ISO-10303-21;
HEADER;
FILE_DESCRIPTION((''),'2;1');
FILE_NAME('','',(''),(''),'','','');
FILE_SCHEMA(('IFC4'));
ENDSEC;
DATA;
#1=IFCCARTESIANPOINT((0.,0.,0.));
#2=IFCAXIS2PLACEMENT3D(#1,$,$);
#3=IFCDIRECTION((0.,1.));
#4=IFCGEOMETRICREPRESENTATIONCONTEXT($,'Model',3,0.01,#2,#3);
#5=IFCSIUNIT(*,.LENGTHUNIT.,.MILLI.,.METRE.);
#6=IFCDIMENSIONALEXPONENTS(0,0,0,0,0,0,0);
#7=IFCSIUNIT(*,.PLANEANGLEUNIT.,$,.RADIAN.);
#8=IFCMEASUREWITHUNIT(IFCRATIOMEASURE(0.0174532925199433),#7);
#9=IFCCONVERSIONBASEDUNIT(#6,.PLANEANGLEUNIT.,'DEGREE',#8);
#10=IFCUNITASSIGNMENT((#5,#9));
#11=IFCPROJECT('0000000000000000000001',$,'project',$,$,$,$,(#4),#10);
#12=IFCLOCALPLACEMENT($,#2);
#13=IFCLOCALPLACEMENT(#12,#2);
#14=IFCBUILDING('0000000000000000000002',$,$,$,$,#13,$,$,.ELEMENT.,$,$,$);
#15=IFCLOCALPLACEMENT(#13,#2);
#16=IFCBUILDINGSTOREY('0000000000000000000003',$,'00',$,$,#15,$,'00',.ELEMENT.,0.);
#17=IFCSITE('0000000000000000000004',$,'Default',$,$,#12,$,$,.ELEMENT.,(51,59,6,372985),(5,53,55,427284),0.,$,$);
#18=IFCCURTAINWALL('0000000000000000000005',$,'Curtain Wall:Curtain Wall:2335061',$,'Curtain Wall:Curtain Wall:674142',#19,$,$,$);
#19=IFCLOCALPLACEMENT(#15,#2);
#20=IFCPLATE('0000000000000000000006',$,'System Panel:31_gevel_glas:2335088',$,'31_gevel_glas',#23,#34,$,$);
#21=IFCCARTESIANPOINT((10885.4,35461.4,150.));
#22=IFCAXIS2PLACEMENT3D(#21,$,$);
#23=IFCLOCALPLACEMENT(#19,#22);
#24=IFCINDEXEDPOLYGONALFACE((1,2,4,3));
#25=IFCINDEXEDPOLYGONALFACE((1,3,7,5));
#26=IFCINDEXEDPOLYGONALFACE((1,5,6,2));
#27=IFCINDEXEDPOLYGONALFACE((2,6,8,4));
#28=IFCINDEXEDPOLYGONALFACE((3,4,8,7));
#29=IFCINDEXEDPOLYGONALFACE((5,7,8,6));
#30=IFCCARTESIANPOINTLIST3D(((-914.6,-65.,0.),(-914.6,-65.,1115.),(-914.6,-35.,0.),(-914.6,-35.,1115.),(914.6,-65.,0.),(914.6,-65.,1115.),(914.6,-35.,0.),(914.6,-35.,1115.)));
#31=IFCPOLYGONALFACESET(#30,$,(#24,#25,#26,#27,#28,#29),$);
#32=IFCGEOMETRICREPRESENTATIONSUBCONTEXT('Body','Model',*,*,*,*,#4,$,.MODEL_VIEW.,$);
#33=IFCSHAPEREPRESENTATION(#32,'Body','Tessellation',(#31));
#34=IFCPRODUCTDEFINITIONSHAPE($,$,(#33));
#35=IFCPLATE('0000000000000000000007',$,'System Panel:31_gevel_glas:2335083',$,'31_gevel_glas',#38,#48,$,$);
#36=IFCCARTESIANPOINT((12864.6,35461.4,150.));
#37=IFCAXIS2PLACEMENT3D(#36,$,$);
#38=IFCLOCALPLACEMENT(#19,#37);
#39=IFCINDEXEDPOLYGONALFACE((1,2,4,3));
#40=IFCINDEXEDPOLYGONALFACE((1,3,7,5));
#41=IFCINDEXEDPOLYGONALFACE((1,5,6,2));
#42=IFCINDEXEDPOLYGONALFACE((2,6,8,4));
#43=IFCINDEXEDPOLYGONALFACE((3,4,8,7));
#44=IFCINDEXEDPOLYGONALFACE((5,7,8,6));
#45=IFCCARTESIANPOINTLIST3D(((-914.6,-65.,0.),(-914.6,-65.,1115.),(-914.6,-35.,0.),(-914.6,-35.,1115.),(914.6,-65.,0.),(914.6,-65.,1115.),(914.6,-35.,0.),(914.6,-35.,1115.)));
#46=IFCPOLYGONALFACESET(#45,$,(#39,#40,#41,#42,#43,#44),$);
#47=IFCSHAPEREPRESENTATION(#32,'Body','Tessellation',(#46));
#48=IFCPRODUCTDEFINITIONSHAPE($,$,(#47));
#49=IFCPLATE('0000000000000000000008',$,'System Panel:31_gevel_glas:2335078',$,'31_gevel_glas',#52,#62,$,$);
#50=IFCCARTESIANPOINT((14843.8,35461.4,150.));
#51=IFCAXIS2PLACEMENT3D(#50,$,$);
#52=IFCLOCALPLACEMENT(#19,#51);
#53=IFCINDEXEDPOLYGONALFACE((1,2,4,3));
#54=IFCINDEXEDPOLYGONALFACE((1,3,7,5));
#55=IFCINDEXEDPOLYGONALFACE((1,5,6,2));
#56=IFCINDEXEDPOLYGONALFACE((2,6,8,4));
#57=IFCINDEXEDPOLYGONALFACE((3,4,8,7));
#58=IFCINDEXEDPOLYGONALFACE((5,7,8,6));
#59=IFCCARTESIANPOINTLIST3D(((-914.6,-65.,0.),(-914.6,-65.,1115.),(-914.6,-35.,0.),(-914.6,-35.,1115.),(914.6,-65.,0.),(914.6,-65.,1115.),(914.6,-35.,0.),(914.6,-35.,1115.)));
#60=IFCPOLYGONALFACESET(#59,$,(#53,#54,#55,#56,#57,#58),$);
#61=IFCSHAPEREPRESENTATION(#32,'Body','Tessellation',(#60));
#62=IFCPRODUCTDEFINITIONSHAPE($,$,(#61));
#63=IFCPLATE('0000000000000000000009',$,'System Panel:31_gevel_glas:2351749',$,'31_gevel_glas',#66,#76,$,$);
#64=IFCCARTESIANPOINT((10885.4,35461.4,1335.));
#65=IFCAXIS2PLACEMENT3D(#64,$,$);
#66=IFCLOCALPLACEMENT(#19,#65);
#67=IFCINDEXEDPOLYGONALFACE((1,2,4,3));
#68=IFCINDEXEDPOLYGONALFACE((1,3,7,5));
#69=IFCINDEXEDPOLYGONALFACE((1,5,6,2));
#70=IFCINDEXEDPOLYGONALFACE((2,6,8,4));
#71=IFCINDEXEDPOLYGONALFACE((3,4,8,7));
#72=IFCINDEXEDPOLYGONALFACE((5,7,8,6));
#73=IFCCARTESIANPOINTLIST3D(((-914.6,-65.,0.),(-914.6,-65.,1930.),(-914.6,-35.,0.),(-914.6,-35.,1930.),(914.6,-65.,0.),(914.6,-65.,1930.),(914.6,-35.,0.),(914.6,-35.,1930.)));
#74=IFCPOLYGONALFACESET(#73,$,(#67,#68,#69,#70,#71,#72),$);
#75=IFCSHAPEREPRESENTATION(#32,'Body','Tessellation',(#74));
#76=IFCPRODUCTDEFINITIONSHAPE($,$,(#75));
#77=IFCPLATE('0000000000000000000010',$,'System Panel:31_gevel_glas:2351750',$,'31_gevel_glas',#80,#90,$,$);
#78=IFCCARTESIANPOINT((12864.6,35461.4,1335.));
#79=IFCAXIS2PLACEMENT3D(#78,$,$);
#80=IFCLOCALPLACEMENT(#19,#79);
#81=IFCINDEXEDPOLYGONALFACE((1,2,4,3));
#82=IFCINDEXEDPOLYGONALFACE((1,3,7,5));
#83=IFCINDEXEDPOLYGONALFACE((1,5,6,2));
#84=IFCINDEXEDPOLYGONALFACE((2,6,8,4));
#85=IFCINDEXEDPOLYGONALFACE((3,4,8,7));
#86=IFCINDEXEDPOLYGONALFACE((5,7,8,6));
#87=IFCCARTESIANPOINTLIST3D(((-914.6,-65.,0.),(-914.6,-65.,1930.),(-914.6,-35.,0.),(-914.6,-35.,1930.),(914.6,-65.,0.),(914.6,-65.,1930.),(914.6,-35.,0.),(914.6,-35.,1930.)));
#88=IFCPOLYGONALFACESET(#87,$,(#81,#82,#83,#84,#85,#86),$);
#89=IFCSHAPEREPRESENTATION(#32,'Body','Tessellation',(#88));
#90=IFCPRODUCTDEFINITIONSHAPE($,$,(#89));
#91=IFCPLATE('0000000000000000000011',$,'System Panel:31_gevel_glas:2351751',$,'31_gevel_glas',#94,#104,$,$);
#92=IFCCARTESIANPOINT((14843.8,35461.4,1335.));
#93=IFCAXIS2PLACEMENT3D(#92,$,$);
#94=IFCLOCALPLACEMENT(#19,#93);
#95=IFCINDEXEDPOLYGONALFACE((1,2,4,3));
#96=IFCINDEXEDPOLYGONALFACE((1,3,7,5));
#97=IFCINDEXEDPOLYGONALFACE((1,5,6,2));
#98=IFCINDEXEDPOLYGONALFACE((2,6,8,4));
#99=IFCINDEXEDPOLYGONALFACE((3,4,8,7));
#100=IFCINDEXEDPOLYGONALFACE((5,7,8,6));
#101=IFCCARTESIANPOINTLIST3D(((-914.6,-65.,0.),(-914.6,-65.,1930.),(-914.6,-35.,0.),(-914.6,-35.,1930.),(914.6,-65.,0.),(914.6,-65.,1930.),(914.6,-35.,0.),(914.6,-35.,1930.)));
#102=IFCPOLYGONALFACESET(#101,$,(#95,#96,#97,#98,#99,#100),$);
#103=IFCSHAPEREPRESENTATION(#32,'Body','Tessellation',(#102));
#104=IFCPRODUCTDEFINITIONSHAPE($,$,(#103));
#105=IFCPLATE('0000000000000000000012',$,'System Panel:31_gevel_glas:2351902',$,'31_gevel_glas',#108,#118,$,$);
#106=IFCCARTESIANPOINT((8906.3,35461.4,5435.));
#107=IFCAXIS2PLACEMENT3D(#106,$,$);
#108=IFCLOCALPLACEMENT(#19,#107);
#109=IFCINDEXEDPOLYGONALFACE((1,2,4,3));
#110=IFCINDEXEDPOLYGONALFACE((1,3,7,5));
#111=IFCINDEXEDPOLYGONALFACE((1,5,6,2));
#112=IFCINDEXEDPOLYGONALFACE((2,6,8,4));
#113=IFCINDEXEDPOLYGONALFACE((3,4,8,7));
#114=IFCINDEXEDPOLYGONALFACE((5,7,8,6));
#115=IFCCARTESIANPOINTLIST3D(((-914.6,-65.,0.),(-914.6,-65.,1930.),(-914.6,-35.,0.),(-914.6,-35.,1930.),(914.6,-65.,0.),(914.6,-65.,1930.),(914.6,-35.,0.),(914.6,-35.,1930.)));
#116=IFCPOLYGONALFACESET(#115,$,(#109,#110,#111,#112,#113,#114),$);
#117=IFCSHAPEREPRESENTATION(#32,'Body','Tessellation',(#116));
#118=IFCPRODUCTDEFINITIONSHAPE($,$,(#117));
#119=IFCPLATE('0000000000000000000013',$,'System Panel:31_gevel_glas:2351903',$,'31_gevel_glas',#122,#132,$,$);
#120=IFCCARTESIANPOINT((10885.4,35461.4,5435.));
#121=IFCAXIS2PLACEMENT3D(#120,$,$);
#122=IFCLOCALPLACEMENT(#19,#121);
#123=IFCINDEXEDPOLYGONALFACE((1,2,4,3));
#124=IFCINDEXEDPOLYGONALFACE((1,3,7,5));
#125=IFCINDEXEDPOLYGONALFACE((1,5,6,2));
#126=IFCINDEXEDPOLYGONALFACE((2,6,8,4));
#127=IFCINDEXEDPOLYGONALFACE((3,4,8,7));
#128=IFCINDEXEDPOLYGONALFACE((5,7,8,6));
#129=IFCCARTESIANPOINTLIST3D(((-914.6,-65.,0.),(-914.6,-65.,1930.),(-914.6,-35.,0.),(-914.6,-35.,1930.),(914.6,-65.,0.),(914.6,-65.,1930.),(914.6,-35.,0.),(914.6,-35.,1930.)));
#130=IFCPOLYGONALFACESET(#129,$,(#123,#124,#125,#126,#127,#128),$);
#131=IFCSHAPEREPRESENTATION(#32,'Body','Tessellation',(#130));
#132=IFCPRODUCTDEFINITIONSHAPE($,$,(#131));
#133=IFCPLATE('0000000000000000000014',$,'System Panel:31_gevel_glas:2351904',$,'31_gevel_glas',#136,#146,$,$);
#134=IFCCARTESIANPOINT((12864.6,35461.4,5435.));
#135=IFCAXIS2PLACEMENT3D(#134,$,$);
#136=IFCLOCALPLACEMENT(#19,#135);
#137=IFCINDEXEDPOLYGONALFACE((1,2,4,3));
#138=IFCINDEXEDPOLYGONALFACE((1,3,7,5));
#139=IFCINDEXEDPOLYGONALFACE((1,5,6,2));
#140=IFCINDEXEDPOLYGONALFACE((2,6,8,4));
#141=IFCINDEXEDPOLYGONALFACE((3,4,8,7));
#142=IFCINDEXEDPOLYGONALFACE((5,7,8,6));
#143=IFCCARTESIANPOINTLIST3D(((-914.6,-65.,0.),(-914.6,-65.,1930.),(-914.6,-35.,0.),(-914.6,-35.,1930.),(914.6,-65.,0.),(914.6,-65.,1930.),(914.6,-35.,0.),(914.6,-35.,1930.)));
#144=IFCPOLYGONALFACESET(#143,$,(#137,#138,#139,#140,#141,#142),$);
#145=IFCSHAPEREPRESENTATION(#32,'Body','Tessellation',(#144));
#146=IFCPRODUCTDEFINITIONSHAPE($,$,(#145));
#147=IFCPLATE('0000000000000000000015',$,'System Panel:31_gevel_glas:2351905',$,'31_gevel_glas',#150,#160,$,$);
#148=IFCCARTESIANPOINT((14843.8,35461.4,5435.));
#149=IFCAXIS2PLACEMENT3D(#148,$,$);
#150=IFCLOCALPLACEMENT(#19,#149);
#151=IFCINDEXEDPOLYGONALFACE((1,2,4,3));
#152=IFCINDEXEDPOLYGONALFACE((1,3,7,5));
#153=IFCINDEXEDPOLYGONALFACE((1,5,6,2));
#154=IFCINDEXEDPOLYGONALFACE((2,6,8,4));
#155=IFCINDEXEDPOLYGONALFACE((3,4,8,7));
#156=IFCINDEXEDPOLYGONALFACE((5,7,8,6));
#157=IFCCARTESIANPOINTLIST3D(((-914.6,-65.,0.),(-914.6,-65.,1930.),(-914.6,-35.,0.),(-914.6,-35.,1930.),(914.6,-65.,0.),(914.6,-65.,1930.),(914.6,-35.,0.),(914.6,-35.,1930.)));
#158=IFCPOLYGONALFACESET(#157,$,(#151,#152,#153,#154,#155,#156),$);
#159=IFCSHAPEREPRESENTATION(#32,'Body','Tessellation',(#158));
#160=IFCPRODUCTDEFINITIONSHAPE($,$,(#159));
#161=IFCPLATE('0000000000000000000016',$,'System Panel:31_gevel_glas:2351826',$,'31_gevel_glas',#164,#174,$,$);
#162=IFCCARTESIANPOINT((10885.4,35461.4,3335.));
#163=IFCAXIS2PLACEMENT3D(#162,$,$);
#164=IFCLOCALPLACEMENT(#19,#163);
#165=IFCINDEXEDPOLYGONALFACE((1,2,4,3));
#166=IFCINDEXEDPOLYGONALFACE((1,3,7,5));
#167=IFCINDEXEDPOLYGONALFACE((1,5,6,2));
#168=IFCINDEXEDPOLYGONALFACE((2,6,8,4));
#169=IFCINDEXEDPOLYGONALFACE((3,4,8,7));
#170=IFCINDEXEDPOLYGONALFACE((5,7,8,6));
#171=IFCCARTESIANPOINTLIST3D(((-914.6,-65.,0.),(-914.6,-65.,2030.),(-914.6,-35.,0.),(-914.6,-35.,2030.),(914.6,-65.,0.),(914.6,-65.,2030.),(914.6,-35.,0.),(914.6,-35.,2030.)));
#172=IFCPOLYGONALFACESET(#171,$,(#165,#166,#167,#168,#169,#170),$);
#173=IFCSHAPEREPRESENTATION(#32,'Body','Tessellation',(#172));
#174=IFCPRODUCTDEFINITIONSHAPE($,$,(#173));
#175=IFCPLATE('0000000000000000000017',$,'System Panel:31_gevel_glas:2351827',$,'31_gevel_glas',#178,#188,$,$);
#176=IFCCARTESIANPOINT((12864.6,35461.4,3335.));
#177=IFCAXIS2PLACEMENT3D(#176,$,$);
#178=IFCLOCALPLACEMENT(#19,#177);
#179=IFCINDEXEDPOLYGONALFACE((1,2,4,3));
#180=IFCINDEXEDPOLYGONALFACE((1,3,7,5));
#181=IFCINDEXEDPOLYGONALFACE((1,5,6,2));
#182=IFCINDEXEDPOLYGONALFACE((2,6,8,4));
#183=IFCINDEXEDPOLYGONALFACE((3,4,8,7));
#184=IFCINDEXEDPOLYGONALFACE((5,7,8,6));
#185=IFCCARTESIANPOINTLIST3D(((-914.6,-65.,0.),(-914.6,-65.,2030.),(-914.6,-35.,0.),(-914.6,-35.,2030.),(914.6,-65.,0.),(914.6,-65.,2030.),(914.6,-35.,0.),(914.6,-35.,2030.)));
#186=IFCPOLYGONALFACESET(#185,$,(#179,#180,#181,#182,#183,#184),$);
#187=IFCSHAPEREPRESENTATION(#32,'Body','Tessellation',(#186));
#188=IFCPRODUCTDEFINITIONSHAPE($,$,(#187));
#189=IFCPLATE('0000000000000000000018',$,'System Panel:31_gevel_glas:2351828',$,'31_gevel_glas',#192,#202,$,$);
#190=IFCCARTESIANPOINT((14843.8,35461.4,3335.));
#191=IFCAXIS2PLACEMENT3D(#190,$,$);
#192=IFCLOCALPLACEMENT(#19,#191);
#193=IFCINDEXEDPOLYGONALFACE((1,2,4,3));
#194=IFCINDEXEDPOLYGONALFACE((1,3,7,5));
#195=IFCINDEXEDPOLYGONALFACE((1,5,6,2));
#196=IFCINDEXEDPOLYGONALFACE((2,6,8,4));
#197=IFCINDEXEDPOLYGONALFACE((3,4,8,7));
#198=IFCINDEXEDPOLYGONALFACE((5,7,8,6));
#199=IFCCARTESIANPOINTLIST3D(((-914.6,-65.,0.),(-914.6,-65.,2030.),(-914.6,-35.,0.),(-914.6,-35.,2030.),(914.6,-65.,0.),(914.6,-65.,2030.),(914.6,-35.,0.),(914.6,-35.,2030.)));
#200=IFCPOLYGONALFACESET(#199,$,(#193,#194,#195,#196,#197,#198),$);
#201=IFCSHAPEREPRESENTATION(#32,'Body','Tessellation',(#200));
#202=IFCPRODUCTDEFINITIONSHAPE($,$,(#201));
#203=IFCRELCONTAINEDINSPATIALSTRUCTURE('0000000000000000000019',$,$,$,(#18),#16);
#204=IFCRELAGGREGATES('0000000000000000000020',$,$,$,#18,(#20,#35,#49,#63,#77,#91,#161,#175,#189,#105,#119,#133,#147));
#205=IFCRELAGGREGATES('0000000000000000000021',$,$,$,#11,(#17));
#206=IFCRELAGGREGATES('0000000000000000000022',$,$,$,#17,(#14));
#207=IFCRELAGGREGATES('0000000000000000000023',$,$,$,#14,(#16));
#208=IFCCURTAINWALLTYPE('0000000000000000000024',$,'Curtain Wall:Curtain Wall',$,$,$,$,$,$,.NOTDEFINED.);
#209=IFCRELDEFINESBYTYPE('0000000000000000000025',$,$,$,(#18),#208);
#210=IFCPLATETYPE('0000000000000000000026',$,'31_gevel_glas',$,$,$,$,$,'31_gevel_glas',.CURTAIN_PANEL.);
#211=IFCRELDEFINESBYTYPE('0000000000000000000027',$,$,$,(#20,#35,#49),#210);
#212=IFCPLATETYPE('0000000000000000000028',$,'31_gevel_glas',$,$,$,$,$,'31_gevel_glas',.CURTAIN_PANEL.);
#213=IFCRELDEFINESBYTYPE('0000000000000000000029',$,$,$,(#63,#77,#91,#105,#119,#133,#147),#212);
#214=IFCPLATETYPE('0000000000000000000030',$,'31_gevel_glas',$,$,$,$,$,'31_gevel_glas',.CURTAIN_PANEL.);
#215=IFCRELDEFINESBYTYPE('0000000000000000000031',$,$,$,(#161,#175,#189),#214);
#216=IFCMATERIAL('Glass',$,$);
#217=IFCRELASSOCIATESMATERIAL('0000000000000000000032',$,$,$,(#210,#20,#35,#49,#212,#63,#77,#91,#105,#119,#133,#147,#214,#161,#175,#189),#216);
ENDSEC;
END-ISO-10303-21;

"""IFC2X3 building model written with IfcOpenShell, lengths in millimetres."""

from ifc_helpers import new_model, entity, si_unit, converted_unit, direction, frame, origin, origin_2d_with_axis, place, context, subcontext, project, spatial, rectangle, extrude, source, transform, mapped, material, type_object, type_shapes, element, aggregate, save


model = new_model("IFC2X3")

# Units and contexts
model_context = context("Model", 3, precision=0.01, world=origin(), true_north=direction((0.0, 1.0)))
body_context = subcontext(model_context, "Body", "Model", "MODEL_VIEW")
ifc_project = project(units=[si_unit("LENGTHUNIT", "METRE", prefix="MILLI"), converted_unit("PLANEANGLEUNIT", "DEGREE", entity("IfcRatioMeasure", 0.0174532925199433), si_unit("PLANEANGLEUNIT", "RADIAN"), dimensions=[0, 0, 0, 0, 0, 0, 0])], contexts=[model_context])

# Site, building, storey
site_placement = place(None, origin())
site = spatial("IfcSite", under=ifc_project, at=site_placement, Name="Default", CompositionType="ELEMENT", RefLatitude=(51, 59, 6, 372985), RefLongitude=(5, 53, 55, 427284), RefElevation=0.0)
building_placement = place(site_placement, origin())
building = spatial("IfcBuilding", under=site, at=building_placement, CompositionType="ELEMENT")
storey_placement = place(building_placement, origin())
storey = spatial("IfcBuildingStorey", under=building, at=storey_placement, Name="00", LongName="00", CompositionType="ELEMENT", Elevation=0.0)

# Curtain wall, plates
curtain_wall_type = type_object("IfcCurtainWallType", Name="Curtain Wall:Curtain Wall", PredefinedType="NOTDEFINED")
curtain_wall_placement = place(storey_placement, origin())
curtain_wall = element("IfcCurtainWall", 1, at=curtain_wall_placement, inside=storey, type_object=curtain_wall_type, Name="Curtain Wall:Curtain Wall:2335061", ObjectType="Curtain Wall:Curtain Wall:674142")
ifc_material_1 = material(Name="Glass")
plate_type_1 = type_object("IfcPlateType", Name="31_gevel_glas", ElementType="31_gevel_glas", PredefinedType="CURTAIN_PANEL", material=ifc_material_1)
shared_shape_1 = source(origin(), body_context, "Body", "SweptSolid", [
    extrude(rectangle(XDim=30.0, YDim=1829.2, at=origin_2d_with_axis()), frame((0.0, -50.0, 0.0), z_axis=(0.0, 0.0, 1.0), x_axis=(0.0, 1.0, 0.0)), (0.0, 0.0, 1.0), 1115.0),
])
type_shapes(plate_type_1, [shared_shape_1])
plate_1_placement = place(curtain_wall_placement, frame((10885.4, 35461.4, 150.0)))
plate_1 = element("IfcPlate", 2, at=plate_1_placement, type_object=plate_type_1, material=ifc_material_1, Name="System Panel:31_gevel_glas:2335088", ObjectType="31_gevel_glas", context=body_context, shape_type="MappedRepresentation", body=[
    mapped(shared_shape_1, transform((0.0, 0.0, 0.0), scale=1.0)),
])
plate_2_placement = place(curtain_wall_placement, frame((12864.6, 35461.4, 150.0)))
plate_2 = element("IfcPlate", 3, at=plate_2_placement, type_object=plate_type_1, material=ifc_material_1, Name="System Panel:31_gevel_glas:2335083", ObjectType="31_gevel_glas", context=body_context, shape_type="MappedRepresentation", body=[
    mapped(shared_shape_1, transform((0.0, 0.0, 0.0), scale=1.0)),
])
plate_3_placement = place(curtain_wall_placement, frame((14843.8, 35461.4, 150.0)))
plate_3 = element("IfcPlate", 4, at=plate_3_placement, type_object=plate_type_1, material=ifc_material_1, Name="System Panel:31_gevel_glas:2335078", ObjectType="31_gevel_glas", context=body_context, shape_type="MappedRepresentation", body=[
    mapped(shared_shape_1, transform((0.0, 0.0, 0.0), scale=1.0)),
])
plate_type_2 = type_object("IfcPlateType", Name="31_gevel_glas", ElementType="31_gevel_glas", PredefinedType="CURTAIN_PANEL", material=ifc_material_1)
shared_shape_2 = source(origin(), body_context, "Body", "SweptSolid", [
    extrude(rectangle(XDim=30.0, YDim=1829.2, at=origin_2d_with_axis()), frame((0.0, -50.0, 0.0), z_axis=(0.0, 0.0, 1.0), x_axis=(0.0, 1.0, 0.0)), (0.0, 0.0, 1.0), 1930.0),
])
type_shapes(plate_type_2, [shared_shape_2])
plate_4_placement = place(curtain_wall_placement, frame((10885.4, 35461.4, 1335.0)))
plate_4 = element("IfcPlate", 5, at=plate_4_placement, type_object=plate_type_2, material=ifc_material_1, Name="System Panel:31_gevel_glas:2351749", ObjectType="31_gevel_glas", context=body_context, shape_type="MappedRepresentation", body=[
    mapped(shared_shape_2, transform((0.0, 0.0, 0.0), scale=1.0)),
])
plate_5_placement = place(curtain_wall_placement, frame((12864.6, 35461.4, 1335.0)))
plate_5 = element("IfcPlate", 6, at=plate_5_placement, type_object=plate_type_2, material=ifc_material_1, Name="System Panel:31_gevel_glas:2351750", ObjectType="31_gevel_glas", context=body_context, shape_type="MappedRepresentation", body=[
    mapped(shared_shape_2, transform((0.0, 0.0, 0.0), scale=1.0)),
])
plate_6_placement = place(curtain_wall_placement, frame((14843.8, 35461.4, 1335.0)))
plate_6 = element("IfcPlate", 7, at=plate_6_placement, type_object=plate_type_2, material=ifc_material_1, Name="System Panel:31_gevel_glas:2351751", ObjectType="31_gevel_glas", context=body_context, shape_type="MappedRepresentation", body=[
    mapped(shared_shape_2, transform((0.0, 0.0, 0.0), scale=1.0)),
])
plate_7_placement = place(curtain_wall_placement, frame((8906.3, 35461.4, 5435.0)))
plate_7 = element("IfcPlate", 8, at=plate_7_placement, type_object=plate_type_2, material=ifc_material_1, Name="System Panel:31_gevel_glas:2351902", ObjectType="31_gevel_glas", context=body_context, shape_type="MappedRepresentation", body=[
    mapped(shared_shape_2, transform((0.0, 0.0, 0.0), scale=1.0)),
])
plate_8_placement = place(curtain_wall_placement, frame((10885.4, 35461.4, 5435.0)))
plate_8 = element("IfcPlate", 9, at=plate_8_placement, type_object=plate_type_2, material=ifc_material_1, Name="System Panel:31_gevel_glas:2351903", ObjectType="31_gevel_glas", context=body_context, shape_type="MappedRepresentation", body=[
    mapped(shared_shape_2, transform((0.0, 0.0, 0.0), scale=1.0)),
])
plate_9_placement = place(curtain_wall_placement, frame((12864.6, 35461.4, 5435.0)))
plate_9 = element("IfcPlate", 10, at=plate_9_placement, type_object=plate_type_2, material=ifc_material_1, Name="System Panel:31_gevel_glas:2351904", ObjectType="31_gevel_glas", context=body_context, shape_type="MappedRepresentation", body=[
    mapped(shared_shape_2, transform((0.0, 0.0, 0.0), scale=1.0)),
])
plate_10_placement = place(curtain_wall_placement, frame((14843.8, 35461.4, 5435.0)))
plate_10 = element("IfcPlate", 11, at=plate_10_placement, type_object=plate_type_2, material=ifc_material_1, Name="System Panel:31_gevel_glas:2351905", ObjectType="31_gevel_glas", context=body_context, shape_type="MappedRepresentation", body=[
    mapped(shared_shape_2, transform((0.0, 0.0, 0.0), scale=1.0)),
])
plate_type_3 = type_object("IfcPlateType", Name="31_gevel_glas", ElementType="31_gevel_glas", PredefinedType="CURTAIN_PANEL", material=ifc_material_1)
shared_shape_3 = source(origin(), body_context, "Body", "SweptSolid", [
    extrude(rectangle(XDim=30.0, YDim=1829.2, at=origin_2d_with_axis()), frame((0.0, -50.0, 0.0), z_axis=(0.0, 0.0, 1.0), x_axis=(0.0, 1.0, 0.0)), (0.0, 0.0, 1.0), 2030.0),
])
type_shapes(plate_type_3, [shared_shape_3])
plate_11_placement = place(curtain_wall_placement, frame((10885.4, 35461.4, 3335.0)))
plate_11 = element("IfcPlate", 12, at=plate_11_placement, type_object=plate_type_3, material=ifc_material_1, Name="System Panel:31_gevel_glas:2351826", ObjectType="31_gevel_glas", context=body_context, shape_type="MappedRepresentation", body=[
    mapped(shared_shape_3, transform((0.0, 0.0, 0.0), scale=1.0)),
])
plate_12_placement = place(curtain_wall_placement, frame((12864.6, 35461.4, 3335.0)))
plate_12 = element("IfcPlate", 13, at=plate_12_placement, type_object=plate_type_3, material=ifc_material_1, Name="System Panel:31_gevel_glas:2351827", ObjectType="31_gevel_glas", context=body_context, shape_type="MappedRepresentation", body=[
    mapped(shared_shape_3, transform((0.0, 0.0, 0.0), scale=1.0)),
])
plate_13_placement = place(curtain_wall_placement, frame((14843.8, 35461.4, 3335.0)))
plate_13 = element("IfcPlate", 14, at=plate_13_placement, type_object=plate_type_3, material=ifc_material_1, Name="System Panel:31_gevel_glas:2351828", ObjectType="31_gevel_glas", context=body_context, shape_type="MappedRepresentation", body=[
    mapped(shared_shape_3, transform((0.0, 0.0, 0.0), scale=1.0)),
])
aggregate(curtain_wall, [plate_1, plate_2, plate_3, plate_4, plate_5, plate_6, plate_11, plate_12, plate_13, plate_7, plate_8, plate_9, plate_10])

save(model, "model.ifc")
